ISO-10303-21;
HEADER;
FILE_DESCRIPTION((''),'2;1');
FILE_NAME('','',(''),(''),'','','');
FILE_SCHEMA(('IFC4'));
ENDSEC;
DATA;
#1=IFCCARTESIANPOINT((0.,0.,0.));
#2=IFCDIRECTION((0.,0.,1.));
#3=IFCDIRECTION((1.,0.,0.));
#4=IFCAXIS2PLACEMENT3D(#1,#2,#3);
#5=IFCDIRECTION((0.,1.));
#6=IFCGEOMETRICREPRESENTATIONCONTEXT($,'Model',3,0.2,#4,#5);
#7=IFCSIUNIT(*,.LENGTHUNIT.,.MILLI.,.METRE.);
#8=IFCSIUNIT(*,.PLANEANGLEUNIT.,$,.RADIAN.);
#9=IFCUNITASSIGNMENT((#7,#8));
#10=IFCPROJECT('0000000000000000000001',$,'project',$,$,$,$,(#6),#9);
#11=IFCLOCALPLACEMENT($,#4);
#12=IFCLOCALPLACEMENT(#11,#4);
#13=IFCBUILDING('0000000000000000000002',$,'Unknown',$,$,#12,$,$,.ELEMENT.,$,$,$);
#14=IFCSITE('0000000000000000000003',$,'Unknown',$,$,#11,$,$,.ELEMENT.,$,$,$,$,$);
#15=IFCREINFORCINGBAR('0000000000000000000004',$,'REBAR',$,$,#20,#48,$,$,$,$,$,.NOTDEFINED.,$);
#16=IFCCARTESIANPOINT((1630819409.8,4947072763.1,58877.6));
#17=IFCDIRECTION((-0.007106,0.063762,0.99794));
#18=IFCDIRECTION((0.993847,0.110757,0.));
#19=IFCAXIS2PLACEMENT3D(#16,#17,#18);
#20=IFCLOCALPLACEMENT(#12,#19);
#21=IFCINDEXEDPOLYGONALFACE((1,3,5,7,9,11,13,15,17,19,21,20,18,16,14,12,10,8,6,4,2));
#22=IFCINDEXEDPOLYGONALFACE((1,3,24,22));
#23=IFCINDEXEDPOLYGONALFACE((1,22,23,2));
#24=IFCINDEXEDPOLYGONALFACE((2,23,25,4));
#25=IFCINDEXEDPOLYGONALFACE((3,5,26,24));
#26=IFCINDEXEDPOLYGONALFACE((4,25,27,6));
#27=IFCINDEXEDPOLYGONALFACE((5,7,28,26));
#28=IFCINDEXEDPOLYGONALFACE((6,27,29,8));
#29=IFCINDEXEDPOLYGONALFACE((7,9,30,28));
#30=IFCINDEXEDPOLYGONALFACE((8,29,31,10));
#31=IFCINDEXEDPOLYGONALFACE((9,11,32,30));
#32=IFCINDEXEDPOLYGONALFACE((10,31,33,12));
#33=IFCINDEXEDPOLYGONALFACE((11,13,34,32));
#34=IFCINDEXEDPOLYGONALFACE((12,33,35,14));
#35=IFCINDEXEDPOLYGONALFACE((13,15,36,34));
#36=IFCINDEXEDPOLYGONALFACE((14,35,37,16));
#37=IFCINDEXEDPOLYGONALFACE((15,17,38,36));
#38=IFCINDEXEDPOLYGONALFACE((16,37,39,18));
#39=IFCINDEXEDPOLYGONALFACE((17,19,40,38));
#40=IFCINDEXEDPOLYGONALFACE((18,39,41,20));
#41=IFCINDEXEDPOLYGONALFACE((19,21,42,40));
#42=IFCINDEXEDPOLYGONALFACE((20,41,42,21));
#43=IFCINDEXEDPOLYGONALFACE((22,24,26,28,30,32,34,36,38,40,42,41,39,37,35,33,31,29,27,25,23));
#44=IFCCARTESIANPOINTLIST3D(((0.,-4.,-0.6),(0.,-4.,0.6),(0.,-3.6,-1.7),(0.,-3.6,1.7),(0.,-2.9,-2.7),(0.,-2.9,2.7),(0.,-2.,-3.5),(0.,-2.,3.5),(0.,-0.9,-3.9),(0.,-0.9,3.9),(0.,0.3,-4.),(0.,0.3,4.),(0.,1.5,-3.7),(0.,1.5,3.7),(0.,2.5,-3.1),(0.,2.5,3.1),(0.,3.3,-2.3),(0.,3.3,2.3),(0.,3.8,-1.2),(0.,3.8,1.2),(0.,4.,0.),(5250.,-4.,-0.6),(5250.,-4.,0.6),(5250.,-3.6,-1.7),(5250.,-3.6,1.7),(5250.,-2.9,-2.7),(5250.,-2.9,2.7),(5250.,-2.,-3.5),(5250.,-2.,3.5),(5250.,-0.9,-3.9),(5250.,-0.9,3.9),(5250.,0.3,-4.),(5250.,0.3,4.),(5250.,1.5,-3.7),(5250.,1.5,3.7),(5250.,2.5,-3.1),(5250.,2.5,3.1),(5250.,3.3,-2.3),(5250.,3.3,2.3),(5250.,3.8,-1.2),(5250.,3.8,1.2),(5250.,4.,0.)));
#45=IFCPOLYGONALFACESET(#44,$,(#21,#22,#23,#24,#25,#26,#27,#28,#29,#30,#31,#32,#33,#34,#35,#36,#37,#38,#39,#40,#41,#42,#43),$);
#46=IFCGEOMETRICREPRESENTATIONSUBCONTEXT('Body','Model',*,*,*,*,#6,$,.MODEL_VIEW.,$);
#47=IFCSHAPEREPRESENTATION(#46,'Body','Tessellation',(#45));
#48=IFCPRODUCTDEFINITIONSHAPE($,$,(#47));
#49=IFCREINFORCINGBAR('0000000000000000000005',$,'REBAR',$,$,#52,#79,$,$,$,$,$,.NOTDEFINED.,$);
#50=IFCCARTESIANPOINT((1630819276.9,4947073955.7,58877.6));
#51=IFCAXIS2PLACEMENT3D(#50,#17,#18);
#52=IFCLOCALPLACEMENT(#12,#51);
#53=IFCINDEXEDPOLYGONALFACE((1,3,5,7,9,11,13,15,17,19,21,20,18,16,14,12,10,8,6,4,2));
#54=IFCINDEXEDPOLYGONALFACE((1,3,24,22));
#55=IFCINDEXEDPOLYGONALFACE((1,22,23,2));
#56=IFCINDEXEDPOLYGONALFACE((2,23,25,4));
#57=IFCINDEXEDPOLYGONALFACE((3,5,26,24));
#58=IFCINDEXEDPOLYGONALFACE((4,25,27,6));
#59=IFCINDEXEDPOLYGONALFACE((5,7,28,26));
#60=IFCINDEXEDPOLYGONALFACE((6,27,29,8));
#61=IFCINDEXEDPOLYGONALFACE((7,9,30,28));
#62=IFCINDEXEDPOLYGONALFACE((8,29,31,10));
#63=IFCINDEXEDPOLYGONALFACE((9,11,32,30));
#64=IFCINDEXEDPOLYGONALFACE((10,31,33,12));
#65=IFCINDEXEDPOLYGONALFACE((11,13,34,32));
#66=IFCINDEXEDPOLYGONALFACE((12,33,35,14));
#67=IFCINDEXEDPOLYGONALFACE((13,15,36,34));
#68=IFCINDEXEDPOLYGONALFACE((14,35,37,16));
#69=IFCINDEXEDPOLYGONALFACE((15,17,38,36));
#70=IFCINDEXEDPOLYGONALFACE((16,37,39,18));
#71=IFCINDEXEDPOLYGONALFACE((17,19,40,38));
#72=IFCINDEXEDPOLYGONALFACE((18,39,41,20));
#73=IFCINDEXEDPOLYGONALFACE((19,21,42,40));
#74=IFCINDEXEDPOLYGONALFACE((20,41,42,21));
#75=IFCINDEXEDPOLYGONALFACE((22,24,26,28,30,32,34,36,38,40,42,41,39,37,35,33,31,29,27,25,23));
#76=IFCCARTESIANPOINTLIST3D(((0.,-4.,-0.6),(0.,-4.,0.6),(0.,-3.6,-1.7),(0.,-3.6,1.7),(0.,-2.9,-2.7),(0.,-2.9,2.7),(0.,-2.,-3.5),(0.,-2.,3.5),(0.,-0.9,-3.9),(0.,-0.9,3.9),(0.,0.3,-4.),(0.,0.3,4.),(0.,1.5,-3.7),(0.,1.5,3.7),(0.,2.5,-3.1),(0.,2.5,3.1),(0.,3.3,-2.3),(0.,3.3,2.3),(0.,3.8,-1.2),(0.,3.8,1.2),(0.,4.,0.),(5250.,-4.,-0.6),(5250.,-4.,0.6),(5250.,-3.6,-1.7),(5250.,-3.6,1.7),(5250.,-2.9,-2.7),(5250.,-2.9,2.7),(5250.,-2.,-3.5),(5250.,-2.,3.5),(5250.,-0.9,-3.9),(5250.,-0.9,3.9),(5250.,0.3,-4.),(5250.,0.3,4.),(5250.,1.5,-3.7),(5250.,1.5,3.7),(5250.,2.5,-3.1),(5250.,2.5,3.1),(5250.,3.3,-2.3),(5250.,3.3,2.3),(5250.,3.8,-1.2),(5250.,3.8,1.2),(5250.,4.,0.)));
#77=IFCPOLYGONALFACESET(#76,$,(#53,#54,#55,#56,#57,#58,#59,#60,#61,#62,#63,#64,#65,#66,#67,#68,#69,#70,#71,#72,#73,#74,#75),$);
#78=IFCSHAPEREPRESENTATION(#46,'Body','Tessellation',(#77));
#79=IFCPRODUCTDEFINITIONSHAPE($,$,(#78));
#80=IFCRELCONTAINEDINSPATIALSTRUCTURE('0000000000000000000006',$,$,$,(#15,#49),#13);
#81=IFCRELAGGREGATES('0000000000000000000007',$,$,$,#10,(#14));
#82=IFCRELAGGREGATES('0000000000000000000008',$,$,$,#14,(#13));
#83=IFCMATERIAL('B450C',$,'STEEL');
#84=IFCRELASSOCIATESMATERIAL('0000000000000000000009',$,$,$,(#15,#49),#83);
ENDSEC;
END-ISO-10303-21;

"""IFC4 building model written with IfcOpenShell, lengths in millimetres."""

from ifc_helpers import new_model, entity, si_unit, direction, frame, origin_with_axes, place, context, subcontext, project, spatial, material, element, save


model = new_model("IFC4")

# Units and contexts
model_context = context("Model", 3, precision=0.2, world=origin_with_axes(), true_north=direction((0.0, 1.0)))
body_context = subcontext(model_context, "Body", "Model", "MODEL_VIEW")
ifc_project = project(units=[si_unit("LENGTHUNIT", "METRE", prefix="MILLI"), si_unit("PLANEANGLEUNIT", "RADIAN")], contexts=[model_context])

# Site, building
site_placement = place(None, origin_with_axes())
site = spatial("IfcSite", under=ifc_project, at=site_placement, Name="Unknown", CompositionType="ELEMENT")
building_placement = place(site_placement, origin_with_axes())
building = spatial("IfcBuilding", under=site, at=building_placement, Name="Unknown", CompositionType="ELEMENT")

# Reinforcing bars
ifc_material = material(Name="B450C", Category="STEEL")
for number, where, z_axis, x_axis, name in (
    (1, (1630819409.8, 4947072763.1, 58877.6), (-0.007106, 0.063762, 0.99794), (0.993847, 0.110757, 0.0), "REBAR"),
):
    element("IfcReinforcingBar", number, at=place(building_placement, frame(where, z_axis=z_axis, x_axis=x_axis)), inside=building, material=ifc_material, Name=name, PredefinedType="NOTDEFINED", context=body_context, shape_type="AdvancedSweptSolid", body=[
        entity("IfcSweptDiskSolid", entity("IfcIndexedPolyCurve", entity("IfcCartesianPointList3D", [[0.0, 0.0, 0.0], [5250.0, 0.0, 0.0]]), [entity("IfcLineIndex", [1, 2])]), 4.0),
    ])
for number, where, z_axis, x_axis, name in (
    (2, (1630819276.9, 4947073955.7, 58877.6), (-0.007106, 0.063762, 0.99794), (0.993847, 0.110757, 0.0), "REBAR"),
):
    element("IfcReinforcingBar", number, at=place(building_placement, frame(where, z_axis=z_axis, x_axis=x_axis)), inside=building, material=ifc_material, Name=name, PredefinedType="NOTDEFINED", context=body_context, shape_type="AdvancedSweptSolid", body=[
        entity("IfcSweptDiskSolid", entity("IfcIndexedPolyCurve", entity("IfcCartesianPointList3D", [[0.0, 0.0, 0.0], [5250.0, 0.0, 0.0]]), [entity("IfcLineIndex", [1, 2])]), 4.0),
    ])

save(model, "model.ifc")
